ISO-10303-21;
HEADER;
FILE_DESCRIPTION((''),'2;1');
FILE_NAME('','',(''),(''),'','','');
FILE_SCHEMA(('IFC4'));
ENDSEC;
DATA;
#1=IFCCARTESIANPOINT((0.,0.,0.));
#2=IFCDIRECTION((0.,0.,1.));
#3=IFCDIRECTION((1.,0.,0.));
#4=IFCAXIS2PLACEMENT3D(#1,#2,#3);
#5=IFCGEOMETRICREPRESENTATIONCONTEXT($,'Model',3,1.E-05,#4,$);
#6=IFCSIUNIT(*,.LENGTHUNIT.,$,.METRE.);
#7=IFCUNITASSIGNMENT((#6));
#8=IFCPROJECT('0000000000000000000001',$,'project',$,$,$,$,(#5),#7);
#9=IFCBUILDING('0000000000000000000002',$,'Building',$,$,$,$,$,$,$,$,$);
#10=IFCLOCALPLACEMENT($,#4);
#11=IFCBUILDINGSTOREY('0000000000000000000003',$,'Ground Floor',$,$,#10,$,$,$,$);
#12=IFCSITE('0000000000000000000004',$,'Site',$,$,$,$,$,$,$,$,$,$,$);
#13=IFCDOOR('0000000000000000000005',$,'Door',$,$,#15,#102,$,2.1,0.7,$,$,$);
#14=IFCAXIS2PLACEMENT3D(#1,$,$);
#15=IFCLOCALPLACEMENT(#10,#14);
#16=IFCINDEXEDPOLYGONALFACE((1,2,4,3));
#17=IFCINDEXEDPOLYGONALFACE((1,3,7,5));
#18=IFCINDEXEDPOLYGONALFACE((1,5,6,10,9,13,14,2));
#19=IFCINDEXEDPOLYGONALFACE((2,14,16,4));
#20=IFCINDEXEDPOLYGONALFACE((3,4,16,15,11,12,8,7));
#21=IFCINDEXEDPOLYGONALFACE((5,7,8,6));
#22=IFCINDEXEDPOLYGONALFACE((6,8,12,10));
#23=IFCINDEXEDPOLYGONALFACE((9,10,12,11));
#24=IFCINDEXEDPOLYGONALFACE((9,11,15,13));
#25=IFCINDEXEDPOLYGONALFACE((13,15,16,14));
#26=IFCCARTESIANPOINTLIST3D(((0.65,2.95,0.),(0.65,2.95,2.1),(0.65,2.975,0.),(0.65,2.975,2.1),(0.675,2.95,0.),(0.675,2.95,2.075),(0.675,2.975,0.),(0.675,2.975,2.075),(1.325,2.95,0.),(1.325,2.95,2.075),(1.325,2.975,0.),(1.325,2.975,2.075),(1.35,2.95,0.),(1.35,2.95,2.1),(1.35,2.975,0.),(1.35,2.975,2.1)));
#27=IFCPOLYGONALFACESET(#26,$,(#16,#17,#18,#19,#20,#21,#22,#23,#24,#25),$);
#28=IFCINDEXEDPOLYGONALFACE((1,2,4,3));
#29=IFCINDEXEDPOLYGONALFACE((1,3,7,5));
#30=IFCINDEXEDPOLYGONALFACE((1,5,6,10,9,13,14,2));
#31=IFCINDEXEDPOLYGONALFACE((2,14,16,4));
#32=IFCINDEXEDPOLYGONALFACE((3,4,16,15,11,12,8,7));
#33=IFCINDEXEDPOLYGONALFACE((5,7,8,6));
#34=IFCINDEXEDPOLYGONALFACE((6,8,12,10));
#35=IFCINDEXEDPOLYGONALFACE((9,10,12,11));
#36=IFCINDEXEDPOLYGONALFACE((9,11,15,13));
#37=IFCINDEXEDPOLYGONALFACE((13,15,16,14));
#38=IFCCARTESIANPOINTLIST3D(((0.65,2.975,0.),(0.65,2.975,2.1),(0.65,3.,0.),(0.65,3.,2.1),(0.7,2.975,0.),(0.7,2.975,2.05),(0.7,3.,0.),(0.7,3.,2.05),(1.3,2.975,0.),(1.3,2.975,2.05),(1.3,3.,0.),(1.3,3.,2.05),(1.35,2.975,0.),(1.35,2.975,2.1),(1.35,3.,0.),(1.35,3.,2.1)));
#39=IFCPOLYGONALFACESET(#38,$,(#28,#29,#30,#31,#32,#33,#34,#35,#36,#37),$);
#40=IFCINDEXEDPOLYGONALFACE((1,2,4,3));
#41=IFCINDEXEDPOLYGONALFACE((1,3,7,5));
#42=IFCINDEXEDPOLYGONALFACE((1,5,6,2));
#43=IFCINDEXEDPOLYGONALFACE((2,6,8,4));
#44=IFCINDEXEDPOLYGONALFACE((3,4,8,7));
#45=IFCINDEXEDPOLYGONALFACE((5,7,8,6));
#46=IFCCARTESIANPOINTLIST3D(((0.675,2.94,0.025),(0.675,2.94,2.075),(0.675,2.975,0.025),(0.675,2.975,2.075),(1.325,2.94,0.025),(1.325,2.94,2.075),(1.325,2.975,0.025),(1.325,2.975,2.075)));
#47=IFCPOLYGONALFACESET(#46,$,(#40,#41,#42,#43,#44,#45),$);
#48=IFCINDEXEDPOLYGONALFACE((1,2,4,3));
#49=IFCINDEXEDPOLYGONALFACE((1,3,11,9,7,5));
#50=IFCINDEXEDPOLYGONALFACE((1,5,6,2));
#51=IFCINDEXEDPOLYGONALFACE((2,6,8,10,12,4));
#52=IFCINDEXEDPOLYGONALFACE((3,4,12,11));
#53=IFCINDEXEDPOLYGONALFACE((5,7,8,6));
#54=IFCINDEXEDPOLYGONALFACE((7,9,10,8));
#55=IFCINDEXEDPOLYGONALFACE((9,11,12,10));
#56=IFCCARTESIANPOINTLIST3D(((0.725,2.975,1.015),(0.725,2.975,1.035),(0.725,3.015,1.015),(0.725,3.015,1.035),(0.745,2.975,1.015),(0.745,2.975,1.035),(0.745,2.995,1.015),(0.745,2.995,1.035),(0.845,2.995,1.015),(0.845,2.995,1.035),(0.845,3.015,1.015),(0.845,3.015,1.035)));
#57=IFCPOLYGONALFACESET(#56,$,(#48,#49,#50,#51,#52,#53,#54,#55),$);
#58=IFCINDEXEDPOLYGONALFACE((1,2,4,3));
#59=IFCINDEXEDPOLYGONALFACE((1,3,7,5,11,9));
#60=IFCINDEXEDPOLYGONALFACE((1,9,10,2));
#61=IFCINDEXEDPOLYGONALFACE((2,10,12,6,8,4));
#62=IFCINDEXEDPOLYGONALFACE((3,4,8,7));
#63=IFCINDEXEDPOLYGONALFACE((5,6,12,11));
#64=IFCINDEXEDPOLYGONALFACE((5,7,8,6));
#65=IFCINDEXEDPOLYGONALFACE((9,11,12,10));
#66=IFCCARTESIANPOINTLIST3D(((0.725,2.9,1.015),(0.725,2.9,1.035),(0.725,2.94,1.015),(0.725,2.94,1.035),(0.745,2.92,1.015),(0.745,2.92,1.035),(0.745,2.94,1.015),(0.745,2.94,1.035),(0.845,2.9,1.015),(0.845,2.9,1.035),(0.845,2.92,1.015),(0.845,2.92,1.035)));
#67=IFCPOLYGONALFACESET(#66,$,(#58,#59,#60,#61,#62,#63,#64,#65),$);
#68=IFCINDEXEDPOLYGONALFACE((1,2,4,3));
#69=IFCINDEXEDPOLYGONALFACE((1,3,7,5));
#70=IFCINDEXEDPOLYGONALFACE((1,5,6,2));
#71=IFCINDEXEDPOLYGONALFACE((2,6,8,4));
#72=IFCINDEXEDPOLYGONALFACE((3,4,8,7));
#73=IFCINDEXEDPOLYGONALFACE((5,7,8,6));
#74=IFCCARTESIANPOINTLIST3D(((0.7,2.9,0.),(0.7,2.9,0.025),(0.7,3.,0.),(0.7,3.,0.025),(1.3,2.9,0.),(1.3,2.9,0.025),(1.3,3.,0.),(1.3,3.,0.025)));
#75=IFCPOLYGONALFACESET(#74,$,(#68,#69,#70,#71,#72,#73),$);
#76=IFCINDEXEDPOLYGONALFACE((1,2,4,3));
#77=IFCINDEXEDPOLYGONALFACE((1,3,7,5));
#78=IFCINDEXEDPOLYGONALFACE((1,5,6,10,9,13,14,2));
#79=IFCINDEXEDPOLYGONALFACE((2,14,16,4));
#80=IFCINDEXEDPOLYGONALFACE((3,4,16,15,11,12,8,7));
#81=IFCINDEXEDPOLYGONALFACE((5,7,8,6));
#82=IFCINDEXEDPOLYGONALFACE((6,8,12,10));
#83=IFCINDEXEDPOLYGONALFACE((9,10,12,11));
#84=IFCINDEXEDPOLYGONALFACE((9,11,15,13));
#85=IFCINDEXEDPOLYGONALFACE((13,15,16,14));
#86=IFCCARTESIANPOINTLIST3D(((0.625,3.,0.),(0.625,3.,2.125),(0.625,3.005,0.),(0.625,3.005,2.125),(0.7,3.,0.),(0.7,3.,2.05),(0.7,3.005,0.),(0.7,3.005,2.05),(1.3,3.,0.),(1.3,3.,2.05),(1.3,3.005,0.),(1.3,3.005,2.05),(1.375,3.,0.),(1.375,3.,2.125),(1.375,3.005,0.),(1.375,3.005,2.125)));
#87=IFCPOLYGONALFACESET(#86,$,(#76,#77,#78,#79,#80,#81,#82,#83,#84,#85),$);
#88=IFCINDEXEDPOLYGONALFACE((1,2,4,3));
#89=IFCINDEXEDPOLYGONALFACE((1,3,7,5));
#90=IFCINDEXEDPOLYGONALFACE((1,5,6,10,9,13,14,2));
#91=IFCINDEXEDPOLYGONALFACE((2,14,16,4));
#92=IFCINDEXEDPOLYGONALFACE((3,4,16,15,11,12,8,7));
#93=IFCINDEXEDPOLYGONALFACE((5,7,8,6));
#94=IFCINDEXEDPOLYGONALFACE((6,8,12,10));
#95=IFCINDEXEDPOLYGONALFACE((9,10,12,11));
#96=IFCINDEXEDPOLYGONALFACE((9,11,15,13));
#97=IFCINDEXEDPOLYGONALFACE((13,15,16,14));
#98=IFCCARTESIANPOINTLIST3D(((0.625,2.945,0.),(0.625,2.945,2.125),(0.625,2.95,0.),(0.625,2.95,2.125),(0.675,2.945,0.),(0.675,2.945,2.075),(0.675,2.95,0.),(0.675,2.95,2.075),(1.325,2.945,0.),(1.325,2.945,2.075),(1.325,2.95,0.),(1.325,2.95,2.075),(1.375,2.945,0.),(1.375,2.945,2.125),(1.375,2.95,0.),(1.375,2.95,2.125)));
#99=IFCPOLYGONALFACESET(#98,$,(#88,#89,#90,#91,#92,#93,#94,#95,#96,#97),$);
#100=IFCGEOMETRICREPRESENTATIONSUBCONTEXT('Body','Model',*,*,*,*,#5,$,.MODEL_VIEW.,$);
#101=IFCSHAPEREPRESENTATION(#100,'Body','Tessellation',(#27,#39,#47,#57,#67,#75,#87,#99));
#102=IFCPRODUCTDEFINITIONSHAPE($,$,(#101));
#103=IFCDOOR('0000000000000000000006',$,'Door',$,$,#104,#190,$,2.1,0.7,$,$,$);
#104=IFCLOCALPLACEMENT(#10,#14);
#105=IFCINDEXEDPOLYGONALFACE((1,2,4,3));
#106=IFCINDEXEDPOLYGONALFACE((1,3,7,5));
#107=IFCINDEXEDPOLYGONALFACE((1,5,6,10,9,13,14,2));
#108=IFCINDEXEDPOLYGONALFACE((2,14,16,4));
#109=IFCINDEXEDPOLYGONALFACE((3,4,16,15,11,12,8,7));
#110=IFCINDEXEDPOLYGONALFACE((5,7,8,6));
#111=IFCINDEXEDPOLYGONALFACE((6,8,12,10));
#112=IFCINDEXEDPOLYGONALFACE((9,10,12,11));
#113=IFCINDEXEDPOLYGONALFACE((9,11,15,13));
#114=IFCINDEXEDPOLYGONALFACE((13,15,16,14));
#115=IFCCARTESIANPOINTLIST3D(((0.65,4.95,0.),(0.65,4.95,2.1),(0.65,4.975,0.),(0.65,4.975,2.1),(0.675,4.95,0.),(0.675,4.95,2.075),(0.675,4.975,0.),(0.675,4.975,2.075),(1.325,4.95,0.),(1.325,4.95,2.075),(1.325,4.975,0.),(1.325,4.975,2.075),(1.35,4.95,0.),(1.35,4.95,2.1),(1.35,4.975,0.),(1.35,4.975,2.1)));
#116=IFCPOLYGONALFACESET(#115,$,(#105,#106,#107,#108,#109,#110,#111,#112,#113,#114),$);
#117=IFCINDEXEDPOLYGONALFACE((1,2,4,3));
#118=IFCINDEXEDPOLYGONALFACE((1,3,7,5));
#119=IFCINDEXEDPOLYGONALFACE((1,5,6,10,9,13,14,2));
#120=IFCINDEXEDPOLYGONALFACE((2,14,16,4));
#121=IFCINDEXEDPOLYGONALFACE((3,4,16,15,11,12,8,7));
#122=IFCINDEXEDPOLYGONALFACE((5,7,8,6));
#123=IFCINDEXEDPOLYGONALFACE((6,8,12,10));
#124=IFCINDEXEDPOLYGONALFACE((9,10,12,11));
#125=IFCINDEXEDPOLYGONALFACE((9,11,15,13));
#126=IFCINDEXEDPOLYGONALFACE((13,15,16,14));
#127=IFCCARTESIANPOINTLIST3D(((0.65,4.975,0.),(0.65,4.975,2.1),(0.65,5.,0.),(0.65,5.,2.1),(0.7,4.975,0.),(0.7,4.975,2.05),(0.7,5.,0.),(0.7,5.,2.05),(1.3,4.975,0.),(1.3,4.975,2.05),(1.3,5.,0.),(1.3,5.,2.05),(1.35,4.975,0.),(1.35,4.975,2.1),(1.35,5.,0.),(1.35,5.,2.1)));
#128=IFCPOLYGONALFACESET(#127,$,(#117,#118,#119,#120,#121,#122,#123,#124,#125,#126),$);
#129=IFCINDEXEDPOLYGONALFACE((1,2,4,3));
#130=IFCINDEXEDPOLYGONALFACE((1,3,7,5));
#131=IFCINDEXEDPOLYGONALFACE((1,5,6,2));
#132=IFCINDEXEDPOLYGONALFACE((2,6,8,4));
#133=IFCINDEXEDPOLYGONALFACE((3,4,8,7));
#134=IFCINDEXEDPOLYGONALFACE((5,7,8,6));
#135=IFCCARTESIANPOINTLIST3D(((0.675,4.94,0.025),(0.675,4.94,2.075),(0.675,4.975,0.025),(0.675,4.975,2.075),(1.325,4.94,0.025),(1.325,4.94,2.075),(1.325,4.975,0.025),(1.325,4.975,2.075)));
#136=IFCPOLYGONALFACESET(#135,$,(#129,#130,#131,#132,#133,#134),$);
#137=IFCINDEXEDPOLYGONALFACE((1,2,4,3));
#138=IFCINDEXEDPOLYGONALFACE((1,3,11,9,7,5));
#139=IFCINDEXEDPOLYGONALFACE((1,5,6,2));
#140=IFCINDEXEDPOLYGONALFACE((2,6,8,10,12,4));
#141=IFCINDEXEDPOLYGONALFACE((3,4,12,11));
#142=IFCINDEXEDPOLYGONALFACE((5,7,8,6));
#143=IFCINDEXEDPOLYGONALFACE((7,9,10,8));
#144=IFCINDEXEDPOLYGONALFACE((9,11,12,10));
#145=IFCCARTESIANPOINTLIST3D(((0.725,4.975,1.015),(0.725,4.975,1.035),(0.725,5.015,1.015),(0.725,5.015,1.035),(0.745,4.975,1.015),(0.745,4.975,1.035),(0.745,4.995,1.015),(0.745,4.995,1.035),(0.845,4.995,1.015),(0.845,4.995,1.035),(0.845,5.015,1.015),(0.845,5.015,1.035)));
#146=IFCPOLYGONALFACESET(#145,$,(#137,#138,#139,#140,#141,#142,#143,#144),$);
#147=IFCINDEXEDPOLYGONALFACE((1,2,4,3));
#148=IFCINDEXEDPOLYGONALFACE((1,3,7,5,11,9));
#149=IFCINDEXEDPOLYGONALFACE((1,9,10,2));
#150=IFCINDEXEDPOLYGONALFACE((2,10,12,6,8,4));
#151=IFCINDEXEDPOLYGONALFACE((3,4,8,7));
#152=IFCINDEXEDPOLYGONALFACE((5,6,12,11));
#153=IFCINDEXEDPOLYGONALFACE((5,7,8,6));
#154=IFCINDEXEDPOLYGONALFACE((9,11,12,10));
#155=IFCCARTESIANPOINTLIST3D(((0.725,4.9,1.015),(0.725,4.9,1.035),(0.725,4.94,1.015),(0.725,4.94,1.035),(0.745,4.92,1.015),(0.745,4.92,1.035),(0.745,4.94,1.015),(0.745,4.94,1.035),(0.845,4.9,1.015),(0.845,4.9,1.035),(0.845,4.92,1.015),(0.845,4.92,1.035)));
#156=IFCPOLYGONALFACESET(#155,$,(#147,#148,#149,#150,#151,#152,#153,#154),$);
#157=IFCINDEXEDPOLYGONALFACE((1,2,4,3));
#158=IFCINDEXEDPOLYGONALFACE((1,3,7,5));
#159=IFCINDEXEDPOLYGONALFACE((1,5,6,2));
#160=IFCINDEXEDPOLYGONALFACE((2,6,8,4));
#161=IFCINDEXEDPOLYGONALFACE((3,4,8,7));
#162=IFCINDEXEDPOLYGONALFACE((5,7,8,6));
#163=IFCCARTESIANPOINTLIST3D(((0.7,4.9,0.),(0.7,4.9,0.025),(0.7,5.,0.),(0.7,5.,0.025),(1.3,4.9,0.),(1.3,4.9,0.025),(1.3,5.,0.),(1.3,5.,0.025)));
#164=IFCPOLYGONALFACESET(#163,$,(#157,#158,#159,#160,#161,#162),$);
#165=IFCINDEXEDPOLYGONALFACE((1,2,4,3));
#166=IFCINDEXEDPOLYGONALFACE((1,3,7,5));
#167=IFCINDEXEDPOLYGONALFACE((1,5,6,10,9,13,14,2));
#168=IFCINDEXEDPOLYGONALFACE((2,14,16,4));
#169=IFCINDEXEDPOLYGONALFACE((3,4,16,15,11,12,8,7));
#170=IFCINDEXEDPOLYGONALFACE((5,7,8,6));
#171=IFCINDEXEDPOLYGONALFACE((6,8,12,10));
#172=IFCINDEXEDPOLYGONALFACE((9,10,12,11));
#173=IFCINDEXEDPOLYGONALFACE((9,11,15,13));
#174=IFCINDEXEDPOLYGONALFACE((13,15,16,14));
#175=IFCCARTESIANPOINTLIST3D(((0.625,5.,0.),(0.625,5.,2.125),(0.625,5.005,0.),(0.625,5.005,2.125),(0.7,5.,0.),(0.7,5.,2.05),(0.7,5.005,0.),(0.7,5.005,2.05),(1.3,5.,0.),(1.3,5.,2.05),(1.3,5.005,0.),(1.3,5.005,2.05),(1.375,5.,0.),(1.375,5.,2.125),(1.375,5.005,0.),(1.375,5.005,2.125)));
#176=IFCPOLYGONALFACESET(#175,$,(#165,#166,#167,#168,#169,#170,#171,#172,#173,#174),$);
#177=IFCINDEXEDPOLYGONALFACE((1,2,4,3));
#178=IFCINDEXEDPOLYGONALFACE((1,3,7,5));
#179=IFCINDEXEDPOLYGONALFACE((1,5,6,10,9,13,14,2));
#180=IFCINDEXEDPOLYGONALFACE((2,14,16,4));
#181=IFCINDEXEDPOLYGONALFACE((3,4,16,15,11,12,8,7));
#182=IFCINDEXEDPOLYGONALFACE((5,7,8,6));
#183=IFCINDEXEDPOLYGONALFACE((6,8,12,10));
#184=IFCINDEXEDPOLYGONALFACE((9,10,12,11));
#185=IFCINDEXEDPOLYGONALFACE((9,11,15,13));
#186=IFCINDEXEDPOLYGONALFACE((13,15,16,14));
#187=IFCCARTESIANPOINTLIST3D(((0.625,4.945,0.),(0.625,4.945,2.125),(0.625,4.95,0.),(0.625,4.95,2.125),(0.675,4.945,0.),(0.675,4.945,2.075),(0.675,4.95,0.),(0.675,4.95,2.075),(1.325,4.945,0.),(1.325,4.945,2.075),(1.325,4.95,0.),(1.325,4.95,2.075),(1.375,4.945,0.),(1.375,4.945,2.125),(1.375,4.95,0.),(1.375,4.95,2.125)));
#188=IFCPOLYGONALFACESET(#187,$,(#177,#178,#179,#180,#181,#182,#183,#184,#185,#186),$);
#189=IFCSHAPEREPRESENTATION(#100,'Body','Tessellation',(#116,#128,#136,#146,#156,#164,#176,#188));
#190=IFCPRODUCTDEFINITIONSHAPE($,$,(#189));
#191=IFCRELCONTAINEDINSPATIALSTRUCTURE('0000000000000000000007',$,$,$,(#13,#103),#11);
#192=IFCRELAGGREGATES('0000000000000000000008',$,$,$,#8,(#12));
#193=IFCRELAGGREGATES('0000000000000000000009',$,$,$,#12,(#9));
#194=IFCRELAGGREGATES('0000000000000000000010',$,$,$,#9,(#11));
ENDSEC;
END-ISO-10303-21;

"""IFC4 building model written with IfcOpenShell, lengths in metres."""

from ifc_helpers import new_model, si_unit, frame, origin_with_axes, place, context, subcontext, project, spatial, line, indexed_curve, outline, extrude, element, save


model = new_model("IFC4")

# Units and contexts
model_context = context("Model", 3, precision=1e-05, world=origin_with_axes())
body_context = subcontext(model_context, "Body", "Model", "MODEL_VIEW")
ifc_project = project(units=[si_unit("LENGTHUNIT", "METRE")], contexts=[model_context])

# Site, building, storey
site = spatial("IfcSite", under=ifc_project, Name="Site")
building = spatial("IfcBuilding", under=site, Name="Building")
storey_placement = place(None, origin_with_axes())
storey = spatial("IfcBuildingStorey", under=building, at=storey_placement, Name="Ground Floor")

# Doors
door_1_placement = place(storey_placement, frame((1.35, 3.0, 0.0), z_axis=(0.0, 0.0, 1.0), x_axis=(-1.0, 0.0, 0.0)))
element("IfcDoor", 1, at=door_1_placement, inside=storey, Name="Door", OverallHeight=2.1, OverallWidth=0.7, context=body_context, shape_type="SweptSolid", body=[
    extrude(outline(indexed_curve([(0.0, 0.0), (0.0, 2.1), (0.7, 2.1), (0.7, 0.0), (0.675, 0.0), (0.675, 2.075), (0.025, 2.075), (0.025, 0.0)], segments=[line(1, 2, 3, 4, 5, 6, 7, 8, 1)])), frame((0.0, 0.025, 0.0), z_axis=(0.0, -1.0, 0.0), x_axis=(1.0, 0.0, 0.0)), (0.0, 0.0, -1.0), 0.025),
    extrude(outline(indexed_curve([(0.0, 0.0), (0.0, 2.1), (0.7, 2.1), (0.7, 0.0), (0.65, 0.0), (0.65, 2.05), (0.05, 2.05), (0.05, 0.0)], segments=[line(1, 2, 3, 4, 5, 6, 7, 8, 1)])), frame((0.0, 0.0, 0.0), z_axis=(0.0, -1.0, 0.0), x_axis=(1.0, 0.0, 0.0)), (0.0, 0.0, -1.0), 0.025),
    extrude(outline(indexed_curve([(0.0, 0.0), (0.65, 0.0), (0.65, 0.035), (0.0, 0.035)], segments=[line(1, 2, 3, 4, 1)])), frame((0.025, 0.025, 0.025), z_axis=(0.0, 0.0, 1.0), x_axis=(1.0, 0.0, 0.0)), (0.0, 0.0, 1.0), 2.05),
    extrude(outline(indexed_curve([(0.0, 0.0), (0.0, -0.04), (-0.12, -0.04), (-0.12, -0.02), (-0.02, -0.02), (-0.02, 0.0)], segments=[line(1, 2, 3, 4, 5, 6, 1)])), frame((0.625, 0.025, 1.015), z_axis=(0.0, 0.0, 1.0), x_axis=(1.0, 0.0, 0.0)), (0.0, 0.0, 1.0), 0.02),
    extrude(outline(indexed_curve([(0.0, 0.0), (0.0, 0.04), (-0.12, 0.04), (-0.12, 0.02), (-0.02, 0.02), (-0.02, 0.0)], segments=[line(1, 2, 3, 4, 5, 6, 1)])), frame((0.625, 0.06, 1.015), z_axis=(0.0, 0.0, 1.0), x_axis=(1.0, 0.0, 0.0)), (0.0, 0.0, 1.0), 0.02),
    extrude(outline(indexed_curve([(0.0, 0.0), (0.6, 0.0), (0.6, 0.1), (0.0, 0.1)], segments=[line(1, 2, 3, 4, 1)])), frame((0.05, 0.0, 0.0), z_axis=(0.0, 0.0, 1.0), x_axis=(1.0, 0.0, 0.0)), (0.0, 0.0, 1.0), 0.025),
    extrude(outline(indexed_curve([(0.0, 0.0), (0.0, 2.125), (0.75, 2.125), (0.75, 0.0), (0.675, 0.0), (0.675, 2.05), (0.075, 2.05), (0.075, 0.0)], segments=[line(1, 2, 3, 4, 5, 6, 7, 8, 1)])), frame((-0.025, -0.005, 0.0), z_axis=(0.0, -1.0, 0.0), x_axis=(1.0, 0.0, 0.0)), (0.0, 0.0, -1.0), 0.005),
    extrude(outline(indexed_curve([(0.0, 0.0), (0.0, 2.125), (0.75, 2.125), (0.75, 0.0), (0.7, 0.0), (0.7, 2.075), (0.05, 2.075), (0.05, 0.0)], segments=[line(1, 2, 3, 4, 5, 6, 7, 8, 1)])), frame((-0.025, 0.05, 0.0), z_axis=(0.0, -1.0, 0.0), x_axis=(1.0, 0.0, 0.0)), (0.0, 0.0, -1.0), 0.005),
])
door_2_placement = place(storey_placement, frame((1.35, 5.0, 0.0), z_axis=(0.0, 0.0, 1.0), x_axis=(-1.0, 0.0, 0.0)))
element("IfcDoor", 2, at=door_2_placement, inside=storey, Name="Door", OverallHeight=2.1, OverallWidth=0.7, context=body_context, shape_type="SweptSolid", body=[
    extrude(outline(indexed_curve([(0.0, 0.0), (0.0, 2.1), (0.7, 2.1), (0.7, 0.0), (0.675, 0.0), (0.675, 2.075), (0.025, 2.075), (0.025, 0.0)], segments=[line(1, 2, 3, 4, 5, 6, 7, 8, 1)])), frame((0.0, 0.025, 0.0), z_axis=(0.0, -1.0, 0.0), x_axis=(1.0, 0.0, 0.0)), (0.0, 0.0, -1.0), 0.025),
    extrude(outline(indexed_curve([(0.0, 0.0), (0.0, 2.1), (0.7, 2.1), (0.7, 0.0), (0.65, 0.0), (0.65, 2.05), (0.05, 2.05), (0.05, 0.0)], segments=[line(1, 2, 3, 4, 5, 6, 7, 8, 1)])), frame((0.0, 0.0, 0.0), z_axis=(0.0, -1.0, 0.0), x_axis=(1.0, 0.0, 0.0)), (0.0, 0.0, -1.0), 0.025),
    extrude(outline(indexed_curve([(0.0, 0.0), (0.65, 0.0), (0.65, 0.035), (0.0, 0.035)], segments=[line(1, 2, 3, 4, 1)])), frame((0.025, 0.025, 0.025), z_axis=(0.0, 0.0, 1.0), x_axis=(1.0, 0.0, 0.0)), (0.0, 0.0, 1.0), 2.05),
    extrude(outline(indexed_curve([(0.0, 0.0), (0.0, -0.04), (-0.12, -0.04), (-0.12, -0.02), (-0.02, -0.02), (-0.02, 0.0)], segments=[line(1, 2, 3, 4, 5, 6, 1)])), frame((0.625, 0.025, 1.015), z_axis=(0.0, 0.0, 1.0), x_axis=(1.0, 0.0, 0.0)), (0.0, 0.0, 1.0), 0.02),
    extrude(outline(indexed_curve([(0.0, 0.0), (0.0, 0.04), (-0.12, 0.04), (-0.12, 0.02), (-0.02, 0.02), (-0.02, 0.0)], segments=[line(1, 2, 3, 4, 5, 6, 1)])), frame((0.625, 0.06, 1.015), z_axis=(0.0, 0.0, 1.0), x_axis=(1.0, 0.0, 0.0)), (0.0, 0.0, 1.0), 0.02),
    extrude(outline(indexed_curve([(0.0, 0.0), (0.6, 0.0), (0.6, 0.1), (0.0, 0.1)], segments=[line(1, 2, 3, 4, 1)])), frame((0.05, 0.0, 0.0), z_axis=(0.0, 0.0, 1.0), x_axis=(1.0, 0.0, 0.0)), (0.0, 0.0, 1.0), 0.025),
    extrude(outline(indexed_curve([(0.0, 0.0), (0.0, 2.125), (0.75, 2.125), (0.75, 0.0), (0.675, 0.0), (0.675, 2.05), (0.075, 2.05), (0.075, 0.0)], segments=[line(1, 2, 3, 4, 5, 6, 7, 8, 1)])), frame((-0.025, -0.005, 0.0), z_axis=(0.0, -1.0, 0.0), x_axis=(1.0, 0.0, 0.0)), (0.0, 0.0, -1.0), 0.005),
    extrude(outline(indexed_curve([(0.0, 0.0), (0.0, 2.125), (0.75, 2.125), (0.75, 0.0), (0.7, 0.0), (0.7, 2.075), (0.05, 2.075), (0.05, 0.0)], segments=[line(1, 2, 3, 4, 5, 6, 7, 8, 1)])), frame((-0.025, 0.05, 0.0), z_axis=(0.0, -1.0, 0.0), x_axis=(1.0, 0.0, 0.0)), (0.0, 0.0, -1.0), 0.005),
])

save(model, "model.ifc")
